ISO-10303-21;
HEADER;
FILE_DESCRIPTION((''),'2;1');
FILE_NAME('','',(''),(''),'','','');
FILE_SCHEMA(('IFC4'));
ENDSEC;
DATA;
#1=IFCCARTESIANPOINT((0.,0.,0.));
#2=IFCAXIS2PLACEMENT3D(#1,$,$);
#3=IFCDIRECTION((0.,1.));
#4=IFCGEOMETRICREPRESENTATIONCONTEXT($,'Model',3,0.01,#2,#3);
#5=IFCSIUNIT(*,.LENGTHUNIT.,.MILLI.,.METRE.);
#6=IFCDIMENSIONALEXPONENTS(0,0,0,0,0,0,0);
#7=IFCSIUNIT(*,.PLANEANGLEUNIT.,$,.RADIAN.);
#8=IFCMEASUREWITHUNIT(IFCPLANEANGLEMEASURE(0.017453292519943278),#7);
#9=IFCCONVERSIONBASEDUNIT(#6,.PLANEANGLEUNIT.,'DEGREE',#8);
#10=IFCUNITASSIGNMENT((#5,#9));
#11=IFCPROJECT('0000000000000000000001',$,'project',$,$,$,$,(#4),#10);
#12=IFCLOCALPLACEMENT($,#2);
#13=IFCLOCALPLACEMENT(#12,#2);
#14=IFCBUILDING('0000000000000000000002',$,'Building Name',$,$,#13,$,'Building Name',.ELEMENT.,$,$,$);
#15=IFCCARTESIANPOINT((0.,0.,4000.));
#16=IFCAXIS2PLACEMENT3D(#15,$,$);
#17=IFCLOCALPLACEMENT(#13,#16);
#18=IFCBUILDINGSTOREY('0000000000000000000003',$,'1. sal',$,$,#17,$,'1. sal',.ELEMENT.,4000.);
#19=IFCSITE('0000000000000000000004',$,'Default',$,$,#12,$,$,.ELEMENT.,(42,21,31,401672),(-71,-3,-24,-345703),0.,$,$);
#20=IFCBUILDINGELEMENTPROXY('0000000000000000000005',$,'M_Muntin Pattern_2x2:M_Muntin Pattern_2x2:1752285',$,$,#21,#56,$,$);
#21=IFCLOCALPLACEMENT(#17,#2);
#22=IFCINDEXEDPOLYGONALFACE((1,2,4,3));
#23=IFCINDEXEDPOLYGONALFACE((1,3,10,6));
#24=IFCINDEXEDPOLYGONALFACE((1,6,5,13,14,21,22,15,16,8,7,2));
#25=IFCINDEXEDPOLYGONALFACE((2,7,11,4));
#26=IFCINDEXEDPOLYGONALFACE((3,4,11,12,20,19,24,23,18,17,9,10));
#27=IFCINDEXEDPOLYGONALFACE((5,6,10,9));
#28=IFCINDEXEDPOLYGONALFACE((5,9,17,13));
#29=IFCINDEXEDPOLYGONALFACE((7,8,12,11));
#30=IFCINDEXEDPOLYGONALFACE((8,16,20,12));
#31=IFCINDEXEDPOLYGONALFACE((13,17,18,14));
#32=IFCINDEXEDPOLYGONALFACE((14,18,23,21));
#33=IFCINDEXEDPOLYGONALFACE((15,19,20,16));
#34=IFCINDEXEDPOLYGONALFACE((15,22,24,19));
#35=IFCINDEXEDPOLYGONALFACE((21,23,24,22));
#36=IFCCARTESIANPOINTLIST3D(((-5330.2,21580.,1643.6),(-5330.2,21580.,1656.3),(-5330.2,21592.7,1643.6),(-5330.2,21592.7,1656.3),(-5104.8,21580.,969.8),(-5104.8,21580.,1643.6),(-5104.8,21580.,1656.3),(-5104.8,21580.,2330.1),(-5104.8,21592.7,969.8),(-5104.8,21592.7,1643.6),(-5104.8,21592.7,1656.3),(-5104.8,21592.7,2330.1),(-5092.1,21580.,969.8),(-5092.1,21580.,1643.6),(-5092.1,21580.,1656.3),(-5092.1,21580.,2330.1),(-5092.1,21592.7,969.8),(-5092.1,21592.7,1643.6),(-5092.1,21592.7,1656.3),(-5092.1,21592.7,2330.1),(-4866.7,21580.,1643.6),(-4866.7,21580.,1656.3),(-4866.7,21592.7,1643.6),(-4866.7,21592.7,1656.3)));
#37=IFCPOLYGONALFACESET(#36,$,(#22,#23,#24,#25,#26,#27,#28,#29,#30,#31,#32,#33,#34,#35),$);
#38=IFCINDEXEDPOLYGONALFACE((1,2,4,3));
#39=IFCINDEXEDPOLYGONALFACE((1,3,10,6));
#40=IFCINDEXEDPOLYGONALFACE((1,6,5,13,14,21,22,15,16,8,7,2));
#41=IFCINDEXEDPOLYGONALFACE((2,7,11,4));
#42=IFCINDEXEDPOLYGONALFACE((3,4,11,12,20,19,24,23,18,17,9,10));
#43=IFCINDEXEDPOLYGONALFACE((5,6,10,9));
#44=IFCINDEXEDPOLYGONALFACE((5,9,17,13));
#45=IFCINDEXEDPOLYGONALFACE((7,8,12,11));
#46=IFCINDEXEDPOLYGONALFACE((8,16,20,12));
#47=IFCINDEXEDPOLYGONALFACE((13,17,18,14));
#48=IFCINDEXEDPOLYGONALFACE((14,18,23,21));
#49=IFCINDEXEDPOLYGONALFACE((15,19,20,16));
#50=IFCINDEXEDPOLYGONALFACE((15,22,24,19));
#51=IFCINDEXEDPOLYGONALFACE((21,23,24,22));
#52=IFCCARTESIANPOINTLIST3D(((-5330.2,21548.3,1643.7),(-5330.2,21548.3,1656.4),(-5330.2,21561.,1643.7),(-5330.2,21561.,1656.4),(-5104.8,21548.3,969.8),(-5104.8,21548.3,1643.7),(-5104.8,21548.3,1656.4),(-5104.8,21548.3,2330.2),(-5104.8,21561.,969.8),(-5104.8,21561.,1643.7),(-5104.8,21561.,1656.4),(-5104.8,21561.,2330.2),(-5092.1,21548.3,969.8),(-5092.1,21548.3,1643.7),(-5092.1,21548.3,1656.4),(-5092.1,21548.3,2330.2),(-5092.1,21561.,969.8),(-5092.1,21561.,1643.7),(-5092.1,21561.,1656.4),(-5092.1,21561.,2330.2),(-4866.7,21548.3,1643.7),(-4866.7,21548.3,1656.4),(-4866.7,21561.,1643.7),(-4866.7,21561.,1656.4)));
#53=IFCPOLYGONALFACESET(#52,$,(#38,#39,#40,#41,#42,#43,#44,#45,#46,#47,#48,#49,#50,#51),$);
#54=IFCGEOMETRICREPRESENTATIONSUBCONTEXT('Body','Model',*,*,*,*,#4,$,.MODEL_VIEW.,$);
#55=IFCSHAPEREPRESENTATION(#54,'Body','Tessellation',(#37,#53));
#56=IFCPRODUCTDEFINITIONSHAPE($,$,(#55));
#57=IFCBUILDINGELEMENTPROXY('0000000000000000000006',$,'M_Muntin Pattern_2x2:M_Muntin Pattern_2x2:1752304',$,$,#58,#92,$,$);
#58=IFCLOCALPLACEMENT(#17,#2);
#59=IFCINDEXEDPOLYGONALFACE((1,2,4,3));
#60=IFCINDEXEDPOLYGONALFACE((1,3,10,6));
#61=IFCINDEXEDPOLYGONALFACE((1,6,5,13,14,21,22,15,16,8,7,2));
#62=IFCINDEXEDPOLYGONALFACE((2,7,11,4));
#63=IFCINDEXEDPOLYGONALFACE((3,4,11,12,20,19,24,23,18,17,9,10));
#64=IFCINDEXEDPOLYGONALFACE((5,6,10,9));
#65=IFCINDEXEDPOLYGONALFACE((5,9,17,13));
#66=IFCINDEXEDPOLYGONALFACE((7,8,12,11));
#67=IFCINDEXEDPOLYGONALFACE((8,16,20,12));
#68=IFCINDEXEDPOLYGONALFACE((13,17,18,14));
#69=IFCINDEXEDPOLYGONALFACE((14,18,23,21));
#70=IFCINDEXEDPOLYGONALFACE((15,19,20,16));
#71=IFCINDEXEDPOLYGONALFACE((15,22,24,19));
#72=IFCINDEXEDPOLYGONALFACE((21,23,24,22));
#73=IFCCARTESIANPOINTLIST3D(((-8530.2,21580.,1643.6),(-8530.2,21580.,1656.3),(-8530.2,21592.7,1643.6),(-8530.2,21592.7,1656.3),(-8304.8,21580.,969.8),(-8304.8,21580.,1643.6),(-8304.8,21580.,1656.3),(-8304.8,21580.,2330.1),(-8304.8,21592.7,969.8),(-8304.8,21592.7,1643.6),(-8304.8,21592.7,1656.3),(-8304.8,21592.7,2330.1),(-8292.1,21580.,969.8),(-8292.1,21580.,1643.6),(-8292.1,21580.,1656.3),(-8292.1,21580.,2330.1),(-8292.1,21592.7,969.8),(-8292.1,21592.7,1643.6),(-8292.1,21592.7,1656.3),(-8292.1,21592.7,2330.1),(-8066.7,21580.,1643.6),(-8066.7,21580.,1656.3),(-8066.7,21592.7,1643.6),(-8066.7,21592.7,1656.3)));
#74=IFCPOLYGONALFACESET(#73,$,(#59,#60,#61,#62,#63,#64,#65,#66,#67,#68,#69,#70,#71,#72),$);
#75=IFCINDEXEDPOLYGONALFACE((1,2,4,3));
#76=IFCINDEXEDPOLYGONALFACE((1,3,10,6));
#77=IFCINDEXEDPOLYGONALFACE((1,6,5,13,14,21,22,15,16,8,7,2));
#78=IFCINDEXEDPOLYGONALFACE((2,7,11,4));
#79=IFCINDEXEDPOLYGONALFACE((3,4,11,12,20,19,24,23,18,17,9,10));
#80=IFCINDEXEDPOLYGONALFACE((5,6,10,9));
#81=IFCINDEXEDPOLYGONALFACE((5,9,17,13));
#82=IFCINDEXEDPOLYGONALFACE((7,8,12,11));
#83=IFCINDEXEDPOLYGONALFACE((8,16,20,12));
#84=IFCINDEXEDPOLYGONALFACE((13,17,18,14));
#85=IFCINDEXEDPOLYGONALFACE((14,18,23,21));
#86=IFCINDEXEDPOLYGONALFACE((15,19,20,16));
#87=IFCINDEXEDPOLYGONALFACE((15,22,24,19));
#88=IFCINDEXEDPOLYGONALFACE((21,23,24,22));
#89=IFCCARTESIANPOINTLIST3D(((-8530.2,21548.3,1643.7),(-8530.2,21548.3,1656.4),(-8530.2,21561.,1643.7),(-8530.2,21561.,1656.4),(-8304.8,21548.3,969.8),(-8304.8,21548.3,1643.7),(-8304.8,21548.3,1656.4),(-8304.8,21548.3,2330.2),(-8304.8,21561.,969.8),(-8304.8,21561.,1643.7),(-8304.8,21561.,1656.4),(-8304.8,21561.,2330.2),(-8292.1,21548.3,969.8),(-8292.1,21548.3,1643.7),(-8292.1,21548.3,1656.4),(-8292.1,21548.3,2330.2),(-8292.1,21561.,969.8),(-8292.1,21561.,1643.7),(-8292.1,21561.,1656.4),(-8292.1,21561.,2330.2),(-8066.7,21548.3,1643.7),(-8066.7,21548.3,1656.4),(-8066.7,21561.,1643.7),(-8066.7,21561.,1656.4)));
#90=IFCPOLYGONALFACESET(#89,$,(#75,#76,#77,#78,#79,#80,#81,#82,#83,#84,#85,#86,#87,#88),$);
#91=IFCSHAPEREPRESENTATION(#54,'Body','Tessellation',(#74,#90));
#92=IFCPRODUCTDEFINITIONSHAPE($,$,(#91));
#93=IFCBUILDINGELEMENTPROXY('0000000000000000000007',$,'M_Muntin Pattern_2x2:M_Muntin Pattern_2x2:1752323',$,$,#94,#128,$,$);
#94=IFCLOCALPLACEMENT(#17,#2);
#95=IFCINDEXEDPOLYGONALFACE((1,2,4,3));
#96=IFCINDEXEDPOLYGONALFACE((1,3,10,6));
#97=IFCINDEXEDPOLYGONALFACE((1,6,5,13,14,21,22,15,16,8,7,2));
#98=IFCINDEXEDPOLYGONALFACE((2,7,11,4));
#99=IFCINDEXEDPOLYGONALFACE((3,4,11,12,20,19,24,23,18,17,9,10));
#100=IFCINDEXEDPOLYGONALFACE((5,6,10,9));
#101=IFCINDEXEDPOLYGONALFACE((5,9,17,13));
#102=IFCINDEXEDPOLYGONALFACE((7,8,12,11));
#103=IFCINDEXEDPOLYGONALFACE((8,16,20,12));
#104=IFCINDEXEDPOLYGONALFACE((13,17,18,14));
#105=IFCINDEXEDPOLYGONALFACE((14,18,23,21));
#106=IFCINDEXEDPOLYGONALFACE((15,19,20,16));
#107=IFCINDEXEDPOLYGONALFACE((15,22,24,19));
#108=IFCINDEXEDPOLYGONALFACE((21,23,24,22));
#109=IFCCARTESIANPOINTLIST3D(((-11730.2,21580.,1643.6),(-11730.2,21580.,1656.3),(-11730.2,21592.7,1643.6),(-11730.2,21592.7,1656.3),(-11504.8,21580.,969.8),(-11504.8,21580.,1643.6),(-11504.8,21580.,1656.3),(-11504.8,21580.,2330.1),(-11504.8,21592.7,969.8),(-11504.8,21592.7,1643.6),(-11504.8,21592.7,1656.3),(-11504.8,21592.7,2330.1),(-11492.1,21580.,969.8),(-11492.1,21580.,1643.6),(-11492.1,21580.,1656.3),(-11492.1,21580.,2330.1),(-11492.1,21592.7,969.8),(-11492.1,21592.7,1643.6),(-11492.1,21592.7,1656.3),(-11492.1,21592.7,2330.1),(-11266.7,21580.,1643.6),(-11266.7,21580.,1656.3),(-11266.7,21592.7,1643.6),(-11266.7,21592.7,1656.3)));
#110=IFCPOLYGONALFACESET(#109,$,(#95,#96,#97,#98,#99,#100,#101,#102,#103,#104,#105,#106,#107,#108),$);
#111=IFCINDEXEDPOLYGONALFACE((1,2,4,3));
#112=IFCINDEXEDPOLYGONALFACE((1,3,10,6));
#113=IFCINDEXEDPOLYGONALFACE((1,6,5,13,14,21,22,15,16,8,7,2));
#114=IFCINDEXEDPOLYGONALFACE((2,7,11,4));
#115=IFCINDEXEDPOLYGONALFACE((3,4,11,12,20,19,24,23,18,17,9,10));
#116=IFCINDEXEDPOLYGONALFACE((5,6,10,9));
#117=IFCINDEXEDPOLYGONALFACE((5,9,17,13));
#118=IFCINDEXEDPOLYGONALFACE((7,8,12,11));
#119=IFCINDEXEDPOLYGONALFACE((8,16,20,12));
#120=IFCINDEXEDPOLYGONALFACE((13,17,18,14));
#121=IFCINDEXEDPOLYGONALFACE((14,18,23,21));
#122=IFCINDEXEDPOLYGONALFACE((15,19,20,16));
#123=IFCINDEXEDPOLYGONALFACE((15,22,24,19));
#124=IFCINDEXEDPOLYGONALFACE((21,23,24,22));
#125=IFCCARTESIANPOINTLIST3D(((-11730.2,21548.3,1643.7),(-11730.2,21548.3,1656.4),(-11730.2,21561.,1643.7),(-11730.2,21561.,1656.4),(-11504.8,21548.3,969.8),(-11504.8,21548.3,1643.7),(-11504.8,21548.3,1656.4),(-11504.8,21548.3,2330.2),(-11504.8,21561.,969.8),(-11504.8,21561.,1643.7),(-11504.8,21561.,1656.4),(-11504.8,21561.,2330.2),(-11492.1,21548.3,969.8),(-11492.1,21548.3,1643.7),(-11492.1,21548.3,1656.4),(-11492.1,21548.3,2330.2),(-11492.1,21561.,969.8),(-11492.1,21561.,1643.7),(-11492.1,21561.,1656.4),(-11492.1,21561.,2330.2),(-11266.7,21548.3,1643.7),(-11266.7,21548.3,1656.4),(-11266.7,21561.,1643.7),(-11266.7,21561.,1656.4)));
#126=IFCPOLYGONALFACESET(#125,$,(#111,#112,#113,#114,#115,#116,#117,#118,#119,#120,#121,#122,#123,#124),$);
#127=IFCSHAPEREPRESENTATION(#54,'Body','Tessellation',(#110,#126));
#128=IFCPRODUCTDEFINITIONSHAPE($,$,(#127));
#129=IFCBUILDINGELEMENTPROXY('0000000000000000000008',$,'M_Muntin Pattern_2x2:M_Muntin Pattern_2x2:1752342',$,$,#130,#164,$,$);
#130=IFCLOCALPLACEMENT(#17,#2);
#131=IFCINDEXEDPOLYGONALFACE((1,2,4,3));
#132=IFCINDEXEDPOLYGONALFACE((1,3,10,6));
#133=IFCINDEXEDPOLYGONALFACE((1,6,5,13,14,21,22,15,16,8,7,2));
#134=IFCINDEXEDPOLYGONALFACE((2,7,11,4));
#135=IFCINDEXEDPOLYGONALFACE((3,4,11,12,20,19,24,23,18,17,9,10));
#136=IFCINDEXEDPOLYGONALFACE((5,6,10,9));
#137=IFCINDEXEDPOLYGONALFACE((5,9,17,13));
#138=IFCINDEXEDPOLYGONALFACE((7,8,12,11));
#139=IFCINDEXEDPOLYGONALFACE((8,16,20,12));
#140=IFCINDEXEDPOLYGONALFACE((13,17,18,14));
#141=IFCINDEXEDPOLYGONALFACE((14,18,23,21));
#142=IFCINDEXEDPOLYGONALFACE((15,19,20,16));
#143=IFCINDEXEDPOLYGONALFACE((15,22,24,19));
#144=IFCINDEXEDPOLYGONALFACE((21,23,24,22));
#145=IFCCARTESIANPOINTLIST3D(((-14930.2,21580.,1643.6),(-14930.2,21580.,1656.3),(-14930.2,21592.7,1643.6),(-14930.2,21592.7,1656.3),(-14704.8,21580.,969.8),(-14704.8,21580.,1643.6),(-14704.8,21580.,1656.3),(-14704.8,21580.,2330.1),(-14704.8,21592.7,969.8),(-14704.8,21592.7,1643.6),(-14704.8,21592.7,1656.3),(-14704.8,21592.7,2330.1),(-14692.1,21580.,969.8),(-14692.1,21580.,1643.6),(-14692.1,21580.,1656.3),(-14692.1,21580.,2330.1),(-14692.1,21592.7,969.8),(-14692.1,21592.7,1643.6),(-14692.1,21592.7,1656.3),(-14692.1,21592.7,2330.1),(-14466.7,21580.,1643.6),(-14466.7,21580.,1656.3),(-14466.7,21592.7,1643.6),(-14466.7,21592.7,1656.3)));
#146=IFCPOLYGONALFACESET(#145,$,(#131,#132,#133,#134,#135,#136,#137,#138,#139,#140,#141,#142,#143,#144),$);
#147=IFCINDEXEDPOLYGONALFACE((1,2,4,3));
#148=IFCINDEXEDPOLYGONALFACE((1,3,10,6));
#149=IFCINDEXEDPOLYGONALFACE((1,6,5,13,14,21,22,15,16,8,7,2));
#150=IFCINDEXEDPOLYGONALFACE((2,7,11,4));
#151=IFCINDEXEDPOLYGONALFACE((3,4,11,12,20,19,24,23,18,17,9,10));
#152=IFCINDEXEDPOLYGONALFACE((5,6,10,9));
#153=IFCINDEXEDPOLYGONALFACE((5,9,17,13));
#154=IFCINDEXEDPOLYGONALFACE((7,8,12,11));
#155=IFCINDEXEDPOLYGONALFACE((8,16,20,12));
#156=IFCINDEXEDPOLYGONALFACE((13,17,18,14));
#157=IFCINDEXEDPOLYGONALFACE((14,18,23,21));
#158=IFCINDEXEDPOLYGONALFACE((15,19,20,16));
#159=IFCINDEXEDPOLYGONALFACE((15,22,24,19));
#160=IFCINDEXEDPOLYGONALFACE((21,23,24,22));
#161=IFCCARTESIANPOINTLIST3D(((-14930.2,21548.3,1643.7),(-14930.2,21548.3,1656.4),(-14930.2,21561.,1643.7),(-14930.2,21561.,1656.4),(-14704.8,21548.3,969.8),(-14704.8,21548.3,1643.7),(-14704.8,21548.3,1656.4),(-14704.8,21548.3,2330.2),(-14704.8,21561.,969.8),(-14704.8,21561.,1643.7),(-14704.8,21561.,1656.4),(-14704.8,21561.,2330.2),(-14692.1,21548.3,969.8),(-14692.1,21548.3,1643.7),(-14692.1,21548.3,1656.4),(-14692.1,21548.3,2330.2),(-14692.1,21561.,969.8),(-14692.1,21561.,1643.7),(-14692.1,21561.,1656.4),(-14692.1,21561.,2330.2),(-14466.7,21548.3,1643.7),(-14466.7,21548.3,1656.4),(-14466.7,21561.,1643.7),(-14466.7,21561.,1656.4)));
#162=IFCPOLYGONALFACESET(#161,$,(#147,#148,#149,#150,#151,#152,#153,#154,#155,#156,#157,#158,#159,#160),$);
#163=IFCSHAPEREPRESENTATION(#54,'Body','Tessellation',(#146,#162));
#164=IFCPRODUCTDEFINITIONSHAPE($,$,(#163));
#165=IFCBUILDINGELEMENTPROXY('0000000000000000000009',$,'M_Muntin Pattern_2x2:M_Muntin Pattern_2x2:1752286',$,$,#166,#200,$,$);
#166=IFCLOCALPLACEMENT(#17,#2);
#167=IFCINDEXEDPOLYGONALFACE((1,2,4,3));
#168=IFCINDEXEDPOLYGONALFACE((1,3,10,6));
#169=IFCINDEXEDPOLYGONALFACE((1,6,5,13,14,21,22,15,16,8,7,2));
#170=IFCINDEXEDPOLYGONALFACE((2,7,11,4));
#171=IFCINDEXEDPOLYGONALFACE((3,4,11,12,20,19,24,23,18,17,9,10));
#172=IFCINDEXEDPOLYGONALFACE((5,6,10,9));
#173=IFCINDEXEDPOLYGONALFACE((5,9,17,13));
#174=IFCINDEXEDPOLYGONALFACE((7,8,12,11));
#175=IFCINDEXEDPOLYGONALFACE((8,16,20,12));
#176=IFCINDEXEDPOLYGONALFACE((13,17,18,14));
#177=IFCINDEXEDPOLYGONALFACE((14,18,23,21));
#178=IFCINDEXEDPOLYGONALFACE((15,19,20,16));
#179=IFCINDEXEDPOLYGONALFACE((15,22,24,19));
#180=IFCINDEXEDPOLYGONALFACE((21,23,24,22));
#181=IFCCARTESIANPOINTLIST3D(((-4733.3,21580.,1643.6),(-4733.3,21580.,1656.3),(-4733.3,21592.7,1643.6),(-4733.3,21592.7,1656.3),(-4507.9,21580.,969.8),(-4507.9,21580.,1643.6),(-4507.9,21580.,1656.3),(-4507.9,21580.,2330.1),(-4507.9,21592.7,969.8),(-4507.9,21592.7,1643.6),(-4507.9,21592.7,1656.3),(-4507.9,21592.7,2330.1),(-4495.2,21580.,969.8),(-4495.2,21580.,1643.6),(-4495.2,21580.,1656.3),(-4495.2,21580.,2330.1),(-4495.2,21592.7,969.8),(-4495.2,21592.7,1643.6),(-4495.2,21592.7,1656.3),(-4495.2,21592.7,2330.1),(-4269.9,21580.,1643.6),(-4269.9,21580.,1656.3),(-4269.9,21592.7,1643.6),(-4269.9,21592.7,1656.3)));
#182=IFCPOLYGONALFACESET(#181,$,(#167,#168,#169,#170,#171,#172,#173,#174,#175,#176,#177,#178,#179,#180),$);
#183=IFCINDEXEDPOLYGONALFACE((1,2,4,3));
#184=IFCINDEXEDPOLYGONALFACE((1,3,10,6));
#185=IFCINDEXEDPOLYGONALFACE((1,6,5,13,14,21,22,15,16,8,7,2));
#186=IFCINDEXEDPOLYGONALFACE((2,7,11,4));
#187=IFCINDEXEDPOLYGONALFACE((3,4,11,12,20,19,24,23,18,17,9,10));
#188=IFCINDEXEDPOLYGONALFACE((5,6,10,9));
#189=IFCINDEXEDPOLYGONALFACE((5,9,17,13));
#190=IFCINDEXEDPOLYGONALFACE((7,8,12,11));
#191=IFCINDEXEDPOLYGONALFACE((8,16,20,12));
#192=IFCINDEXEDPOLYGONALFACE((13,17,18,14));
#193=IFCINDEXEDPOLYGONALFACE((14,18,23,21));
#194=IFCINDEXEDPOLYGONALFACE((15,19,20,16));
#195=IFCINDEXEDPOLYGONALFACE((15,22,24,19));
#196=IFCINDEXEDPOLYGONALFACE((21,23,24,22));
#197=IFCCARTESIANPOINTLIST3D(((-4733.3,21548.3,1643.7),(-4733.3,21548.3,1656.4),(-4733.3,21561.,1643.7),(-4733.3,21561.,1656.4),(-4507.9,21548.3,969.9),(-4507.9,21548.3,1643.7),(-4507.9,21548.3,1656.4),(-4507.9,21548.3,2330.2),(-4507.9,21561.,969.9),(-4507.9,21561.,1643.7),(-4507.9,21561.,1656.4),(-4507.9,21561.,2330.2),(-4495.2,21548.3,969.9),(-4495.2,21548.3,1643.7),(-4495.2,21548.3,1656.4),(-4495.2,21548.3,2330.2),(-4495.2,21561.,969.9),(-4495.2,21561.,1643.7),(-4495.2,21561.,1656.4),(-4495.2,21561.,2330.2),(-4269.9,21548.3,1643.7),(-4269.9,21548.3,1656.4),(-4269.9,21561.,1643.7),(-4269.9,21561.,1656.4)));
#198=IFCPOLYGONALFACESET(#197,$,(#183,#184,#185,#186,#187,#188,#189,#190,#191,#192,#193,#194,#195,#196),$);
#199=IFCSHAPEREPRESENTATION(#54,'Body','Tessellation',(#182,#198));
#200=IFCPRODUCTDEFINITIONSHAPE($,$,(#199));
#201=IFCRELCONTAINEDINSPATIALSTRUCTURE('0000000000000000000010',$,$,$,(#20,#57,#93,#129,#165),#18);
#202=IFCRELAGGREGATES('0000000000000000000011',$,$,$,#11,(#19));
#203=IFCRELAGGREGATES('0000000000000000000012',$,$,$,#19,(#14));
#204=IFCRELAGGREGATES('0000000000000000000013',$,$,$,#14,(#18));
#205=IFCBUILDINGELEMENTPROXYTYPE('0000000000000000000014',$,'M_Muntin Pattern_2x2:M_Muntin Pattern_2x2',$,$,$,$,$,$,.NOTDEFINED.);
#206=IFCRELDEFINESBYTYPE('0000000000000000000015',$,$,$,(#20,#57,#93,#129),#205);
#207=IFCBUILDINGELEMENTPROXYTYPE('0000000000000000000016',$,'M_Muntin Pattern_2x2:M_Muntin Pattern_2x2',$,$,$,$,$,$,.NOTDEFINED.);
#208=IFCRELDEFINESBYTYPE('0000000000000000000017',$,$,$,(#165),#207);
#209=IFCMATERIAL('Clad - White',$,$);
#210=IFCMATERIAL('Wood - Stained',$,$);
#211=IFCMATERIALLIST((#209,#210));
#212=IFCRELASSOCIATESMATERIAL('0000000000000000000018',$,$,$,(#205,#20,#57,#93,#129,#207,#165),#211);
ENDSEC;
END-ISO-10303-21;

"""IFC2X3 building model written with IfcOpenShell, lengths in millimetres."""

from ifc_helpers import new_model, entity, si_unit, converted_unit, direction, frame, origin, place, context, subcontext, project, spatial, polyline, outline, extrude, source, transform, mapped, material, material_list, type_object, type_shapes, element, save


model = new_model("IFC2X3")

# Units and contexts
model_context = context("Model", 3, precision=0.01, world=origin(), true_north=direction((0.0, 1.0)))
body_context = subcontext(model_context, "Body", "Model", "MODEL_VIEW")
ifc_project = project(units=[si_unit("LENGTHUNIT", "METRE", prefix="MILLI"), converted_unit("PLANEANGLEUNIT", "DEGREE", entity("IfcPlaneAngleMeasure", 0.017453292519943278), si_unit("PLANEANGLEUNIT", "RADIAN"), dimensions=[0, 0, 0, 0, 0, 0, 0])], contexts=[model_context])

# Site, building, storey
site_placement = place(None, origin())
site = spatial("IfcSite", under=ifc_project, at=site_placement, Name="Default", CompositionType="ELEMENT", RefLatitude=(42, 21, 31, 401672), RefLongitude=(-71, -3, -24, -345703), RefElevation=0.0)
building_placement = place(site_placement, origin())
building = spatial("IfcBuilding", under=site, at=building_placement, Name="Building Name", LongName="Building Name", CompositionType="ELEMENT")
storey_placement = place(building_placement, frame((0.0, 0.0, 4000.0)))
storey = spatial("IfcBuildingStorey", under=building, at=storey_placement, Name="1. sal", LongName="1. sal", CompositionType="ELEMENT", Elevation=4000.0)

# Building element proxies
ifc_material_1 = material(Name="Clad - White")
ifc_material_2 = material(Name="Wood - Stained")
ifc_material_list = material_list([ifc_material_1, ifc_material_2])
building_element_proxy_type_1 = type_object("IfcBuildingElementProxyType", Name="M_Muntin Pattern_2x2:M_Muntin Pattern_2x2", PredefinedType="NOTDEFINED", material=ifc_material_list)
shared_shape_1 = source(origin(), body_context, "Body", "SweptSolid", [
    extrude(outline(polyline([(6.4, -6.4), (680.1, -6.4), (680.1, 6.3), (6.4, 6.3), (6.4, 231.7), (-6.3, 231.7), (-6.3, 6.3), (-680.2, 6.3), (-680.2, -6.4), (-6.3, -6.4), (-6.3, -231.7), (6.4, -231.7), (6.4, -6.4)])), frame((0.0, 9.5, 680.1), z_axis=(0.0, 1.0, 0.0), x_axis=(0.0, 0.0, 1.0)), (0.0, 0.0, 1.0), 12.7),
    extrude(outline(polyline([(6.4, -6.4), (680.2, -6.4), (680.2, 6.3), (6.4, 6.3), (6.4, 231.7), (-6.3, 231.7), (-6.3, 6.3), (-680.2, 6.3), (-680.2, -6.4), (-6.3, -6.4), (-6.3, -231.7), (6.4, -231.7), (6.4, -6.4)])), frame((0.0, -22.2, 680.2), z_axis=(0.0, 1.0, 0.0), x_axis=(0.0, 0.0, 1.0)), (0.0, 0.0, 1.0), 12.7),
])
type_shapes(building_element_proxy_type_1, [shared_shape_1])
for number, where, name in (
    (1, (-5098.4, 21570.5, 969.8), "M_Muntin Pattern_2x2:M_Muntin Pattern_2x2:1752285"),
    (2, (-8298.4, 21570.5, 969.8), "M_Muntin Pattern_2x2:M_Muntin Pattern_2x2:1752304"),
    (3, (-11498.4, 21570.5, 969.8), "M_Muntin Pattern_2x2:M_Muntin Pattern_2x2:1752323"),
    (4, (-14698.4, 21570.5, 969.8), "M_Muntin Pattern_2x2:M_Muntin Pattern_2x2:1752342"),
):
    element("IfcBuildingElementProxy", number, at=place(storey_placement, frame(where)), inside=storey, type_object=building_element_proxy_type_1, material=ifc_material_list, Name=name, context=body_context, shape_type="MappedRepresentation", body=[
        mapped(shared_shape_1, transform((0.0, 0.0, 0.0), scale=1.0)),
    ])
building_element_proxy_type_2 = type_object("IfcBuildingElementProxyType", Name="M_Muntin Pattern_2x2:M_Muntin Pattern_2x2", PredefinedType="NOTDEFINED", material=ifc_material_list)
shared_shape_2 = source(origin(), body_context, "Body", "SweptSolid", [
    extrude(outline(polyline([(6.4, -6.4), (680.1, -6.4), (680.1, 6.3), (6.4, 6.3), (6.4, 231.7), (-6.3, 231.7), (-6.3, 6.3), (-680.2, 6.3), (-680.2, -6.4), (-6.3, -6.4), (-6.3, -231.7), (6.4, -231.7), (6.4, -6.4)])), frame((0.0, -22.2, 680.1), z_axis=(0.0, 1.0, 0.0), x_axis=(0.0, 0.0, 1.0)), (0.0, 0.0, 1.0), 12.7),
    extrude(outline(polyline([(6.4, -6.4), (680.2, -6.4), (680.2, 6.3), (6.4, 6.3), (6.4, 231.7), (-6.3, 231.7), (-6.3, 6.3), (-680.2, 6.3), (-680.2, -6.4), (-6.3, -6.4), (-6.3, -231.7), (6.4, -231.7), (6.4, -6.4)])), frame((0.0, 9.5, 680.2), z_axis=(0.0, 1.0, 0.0), x_axis=(0.0, 0.0, 1.0)), (0.0, 0.0, 1.0), 12.7),
])
type_shapes(building_element_proxy_type_2, [shared_shape_2])
for number, where, z_axis, x_axis, name in (
    (5, (-4501.6, 21570.5, 969.9), (0.0, 0.0, 1.0), (-1.0, 0.0, 0.0), "M_Muntin Pattern_2x2:M_Muntin Pattern_2x2:1752286"),
):
    element("IfcBuildingElementProxy", number, at=place(storey_placement, frame(where, z_axis=z_axis, x_axis=x_axis)), inside=storey, type_object=building_element_proxy_type_2, material=ifc_material_list, Name=name, context=body_context, shape_type="MappedRepresentation", body=[
        mapped(shared_shape_2, transform((0.0, 0.0, 0.0), scale=1.0)),
    ])

save(model, "model.ifc")
